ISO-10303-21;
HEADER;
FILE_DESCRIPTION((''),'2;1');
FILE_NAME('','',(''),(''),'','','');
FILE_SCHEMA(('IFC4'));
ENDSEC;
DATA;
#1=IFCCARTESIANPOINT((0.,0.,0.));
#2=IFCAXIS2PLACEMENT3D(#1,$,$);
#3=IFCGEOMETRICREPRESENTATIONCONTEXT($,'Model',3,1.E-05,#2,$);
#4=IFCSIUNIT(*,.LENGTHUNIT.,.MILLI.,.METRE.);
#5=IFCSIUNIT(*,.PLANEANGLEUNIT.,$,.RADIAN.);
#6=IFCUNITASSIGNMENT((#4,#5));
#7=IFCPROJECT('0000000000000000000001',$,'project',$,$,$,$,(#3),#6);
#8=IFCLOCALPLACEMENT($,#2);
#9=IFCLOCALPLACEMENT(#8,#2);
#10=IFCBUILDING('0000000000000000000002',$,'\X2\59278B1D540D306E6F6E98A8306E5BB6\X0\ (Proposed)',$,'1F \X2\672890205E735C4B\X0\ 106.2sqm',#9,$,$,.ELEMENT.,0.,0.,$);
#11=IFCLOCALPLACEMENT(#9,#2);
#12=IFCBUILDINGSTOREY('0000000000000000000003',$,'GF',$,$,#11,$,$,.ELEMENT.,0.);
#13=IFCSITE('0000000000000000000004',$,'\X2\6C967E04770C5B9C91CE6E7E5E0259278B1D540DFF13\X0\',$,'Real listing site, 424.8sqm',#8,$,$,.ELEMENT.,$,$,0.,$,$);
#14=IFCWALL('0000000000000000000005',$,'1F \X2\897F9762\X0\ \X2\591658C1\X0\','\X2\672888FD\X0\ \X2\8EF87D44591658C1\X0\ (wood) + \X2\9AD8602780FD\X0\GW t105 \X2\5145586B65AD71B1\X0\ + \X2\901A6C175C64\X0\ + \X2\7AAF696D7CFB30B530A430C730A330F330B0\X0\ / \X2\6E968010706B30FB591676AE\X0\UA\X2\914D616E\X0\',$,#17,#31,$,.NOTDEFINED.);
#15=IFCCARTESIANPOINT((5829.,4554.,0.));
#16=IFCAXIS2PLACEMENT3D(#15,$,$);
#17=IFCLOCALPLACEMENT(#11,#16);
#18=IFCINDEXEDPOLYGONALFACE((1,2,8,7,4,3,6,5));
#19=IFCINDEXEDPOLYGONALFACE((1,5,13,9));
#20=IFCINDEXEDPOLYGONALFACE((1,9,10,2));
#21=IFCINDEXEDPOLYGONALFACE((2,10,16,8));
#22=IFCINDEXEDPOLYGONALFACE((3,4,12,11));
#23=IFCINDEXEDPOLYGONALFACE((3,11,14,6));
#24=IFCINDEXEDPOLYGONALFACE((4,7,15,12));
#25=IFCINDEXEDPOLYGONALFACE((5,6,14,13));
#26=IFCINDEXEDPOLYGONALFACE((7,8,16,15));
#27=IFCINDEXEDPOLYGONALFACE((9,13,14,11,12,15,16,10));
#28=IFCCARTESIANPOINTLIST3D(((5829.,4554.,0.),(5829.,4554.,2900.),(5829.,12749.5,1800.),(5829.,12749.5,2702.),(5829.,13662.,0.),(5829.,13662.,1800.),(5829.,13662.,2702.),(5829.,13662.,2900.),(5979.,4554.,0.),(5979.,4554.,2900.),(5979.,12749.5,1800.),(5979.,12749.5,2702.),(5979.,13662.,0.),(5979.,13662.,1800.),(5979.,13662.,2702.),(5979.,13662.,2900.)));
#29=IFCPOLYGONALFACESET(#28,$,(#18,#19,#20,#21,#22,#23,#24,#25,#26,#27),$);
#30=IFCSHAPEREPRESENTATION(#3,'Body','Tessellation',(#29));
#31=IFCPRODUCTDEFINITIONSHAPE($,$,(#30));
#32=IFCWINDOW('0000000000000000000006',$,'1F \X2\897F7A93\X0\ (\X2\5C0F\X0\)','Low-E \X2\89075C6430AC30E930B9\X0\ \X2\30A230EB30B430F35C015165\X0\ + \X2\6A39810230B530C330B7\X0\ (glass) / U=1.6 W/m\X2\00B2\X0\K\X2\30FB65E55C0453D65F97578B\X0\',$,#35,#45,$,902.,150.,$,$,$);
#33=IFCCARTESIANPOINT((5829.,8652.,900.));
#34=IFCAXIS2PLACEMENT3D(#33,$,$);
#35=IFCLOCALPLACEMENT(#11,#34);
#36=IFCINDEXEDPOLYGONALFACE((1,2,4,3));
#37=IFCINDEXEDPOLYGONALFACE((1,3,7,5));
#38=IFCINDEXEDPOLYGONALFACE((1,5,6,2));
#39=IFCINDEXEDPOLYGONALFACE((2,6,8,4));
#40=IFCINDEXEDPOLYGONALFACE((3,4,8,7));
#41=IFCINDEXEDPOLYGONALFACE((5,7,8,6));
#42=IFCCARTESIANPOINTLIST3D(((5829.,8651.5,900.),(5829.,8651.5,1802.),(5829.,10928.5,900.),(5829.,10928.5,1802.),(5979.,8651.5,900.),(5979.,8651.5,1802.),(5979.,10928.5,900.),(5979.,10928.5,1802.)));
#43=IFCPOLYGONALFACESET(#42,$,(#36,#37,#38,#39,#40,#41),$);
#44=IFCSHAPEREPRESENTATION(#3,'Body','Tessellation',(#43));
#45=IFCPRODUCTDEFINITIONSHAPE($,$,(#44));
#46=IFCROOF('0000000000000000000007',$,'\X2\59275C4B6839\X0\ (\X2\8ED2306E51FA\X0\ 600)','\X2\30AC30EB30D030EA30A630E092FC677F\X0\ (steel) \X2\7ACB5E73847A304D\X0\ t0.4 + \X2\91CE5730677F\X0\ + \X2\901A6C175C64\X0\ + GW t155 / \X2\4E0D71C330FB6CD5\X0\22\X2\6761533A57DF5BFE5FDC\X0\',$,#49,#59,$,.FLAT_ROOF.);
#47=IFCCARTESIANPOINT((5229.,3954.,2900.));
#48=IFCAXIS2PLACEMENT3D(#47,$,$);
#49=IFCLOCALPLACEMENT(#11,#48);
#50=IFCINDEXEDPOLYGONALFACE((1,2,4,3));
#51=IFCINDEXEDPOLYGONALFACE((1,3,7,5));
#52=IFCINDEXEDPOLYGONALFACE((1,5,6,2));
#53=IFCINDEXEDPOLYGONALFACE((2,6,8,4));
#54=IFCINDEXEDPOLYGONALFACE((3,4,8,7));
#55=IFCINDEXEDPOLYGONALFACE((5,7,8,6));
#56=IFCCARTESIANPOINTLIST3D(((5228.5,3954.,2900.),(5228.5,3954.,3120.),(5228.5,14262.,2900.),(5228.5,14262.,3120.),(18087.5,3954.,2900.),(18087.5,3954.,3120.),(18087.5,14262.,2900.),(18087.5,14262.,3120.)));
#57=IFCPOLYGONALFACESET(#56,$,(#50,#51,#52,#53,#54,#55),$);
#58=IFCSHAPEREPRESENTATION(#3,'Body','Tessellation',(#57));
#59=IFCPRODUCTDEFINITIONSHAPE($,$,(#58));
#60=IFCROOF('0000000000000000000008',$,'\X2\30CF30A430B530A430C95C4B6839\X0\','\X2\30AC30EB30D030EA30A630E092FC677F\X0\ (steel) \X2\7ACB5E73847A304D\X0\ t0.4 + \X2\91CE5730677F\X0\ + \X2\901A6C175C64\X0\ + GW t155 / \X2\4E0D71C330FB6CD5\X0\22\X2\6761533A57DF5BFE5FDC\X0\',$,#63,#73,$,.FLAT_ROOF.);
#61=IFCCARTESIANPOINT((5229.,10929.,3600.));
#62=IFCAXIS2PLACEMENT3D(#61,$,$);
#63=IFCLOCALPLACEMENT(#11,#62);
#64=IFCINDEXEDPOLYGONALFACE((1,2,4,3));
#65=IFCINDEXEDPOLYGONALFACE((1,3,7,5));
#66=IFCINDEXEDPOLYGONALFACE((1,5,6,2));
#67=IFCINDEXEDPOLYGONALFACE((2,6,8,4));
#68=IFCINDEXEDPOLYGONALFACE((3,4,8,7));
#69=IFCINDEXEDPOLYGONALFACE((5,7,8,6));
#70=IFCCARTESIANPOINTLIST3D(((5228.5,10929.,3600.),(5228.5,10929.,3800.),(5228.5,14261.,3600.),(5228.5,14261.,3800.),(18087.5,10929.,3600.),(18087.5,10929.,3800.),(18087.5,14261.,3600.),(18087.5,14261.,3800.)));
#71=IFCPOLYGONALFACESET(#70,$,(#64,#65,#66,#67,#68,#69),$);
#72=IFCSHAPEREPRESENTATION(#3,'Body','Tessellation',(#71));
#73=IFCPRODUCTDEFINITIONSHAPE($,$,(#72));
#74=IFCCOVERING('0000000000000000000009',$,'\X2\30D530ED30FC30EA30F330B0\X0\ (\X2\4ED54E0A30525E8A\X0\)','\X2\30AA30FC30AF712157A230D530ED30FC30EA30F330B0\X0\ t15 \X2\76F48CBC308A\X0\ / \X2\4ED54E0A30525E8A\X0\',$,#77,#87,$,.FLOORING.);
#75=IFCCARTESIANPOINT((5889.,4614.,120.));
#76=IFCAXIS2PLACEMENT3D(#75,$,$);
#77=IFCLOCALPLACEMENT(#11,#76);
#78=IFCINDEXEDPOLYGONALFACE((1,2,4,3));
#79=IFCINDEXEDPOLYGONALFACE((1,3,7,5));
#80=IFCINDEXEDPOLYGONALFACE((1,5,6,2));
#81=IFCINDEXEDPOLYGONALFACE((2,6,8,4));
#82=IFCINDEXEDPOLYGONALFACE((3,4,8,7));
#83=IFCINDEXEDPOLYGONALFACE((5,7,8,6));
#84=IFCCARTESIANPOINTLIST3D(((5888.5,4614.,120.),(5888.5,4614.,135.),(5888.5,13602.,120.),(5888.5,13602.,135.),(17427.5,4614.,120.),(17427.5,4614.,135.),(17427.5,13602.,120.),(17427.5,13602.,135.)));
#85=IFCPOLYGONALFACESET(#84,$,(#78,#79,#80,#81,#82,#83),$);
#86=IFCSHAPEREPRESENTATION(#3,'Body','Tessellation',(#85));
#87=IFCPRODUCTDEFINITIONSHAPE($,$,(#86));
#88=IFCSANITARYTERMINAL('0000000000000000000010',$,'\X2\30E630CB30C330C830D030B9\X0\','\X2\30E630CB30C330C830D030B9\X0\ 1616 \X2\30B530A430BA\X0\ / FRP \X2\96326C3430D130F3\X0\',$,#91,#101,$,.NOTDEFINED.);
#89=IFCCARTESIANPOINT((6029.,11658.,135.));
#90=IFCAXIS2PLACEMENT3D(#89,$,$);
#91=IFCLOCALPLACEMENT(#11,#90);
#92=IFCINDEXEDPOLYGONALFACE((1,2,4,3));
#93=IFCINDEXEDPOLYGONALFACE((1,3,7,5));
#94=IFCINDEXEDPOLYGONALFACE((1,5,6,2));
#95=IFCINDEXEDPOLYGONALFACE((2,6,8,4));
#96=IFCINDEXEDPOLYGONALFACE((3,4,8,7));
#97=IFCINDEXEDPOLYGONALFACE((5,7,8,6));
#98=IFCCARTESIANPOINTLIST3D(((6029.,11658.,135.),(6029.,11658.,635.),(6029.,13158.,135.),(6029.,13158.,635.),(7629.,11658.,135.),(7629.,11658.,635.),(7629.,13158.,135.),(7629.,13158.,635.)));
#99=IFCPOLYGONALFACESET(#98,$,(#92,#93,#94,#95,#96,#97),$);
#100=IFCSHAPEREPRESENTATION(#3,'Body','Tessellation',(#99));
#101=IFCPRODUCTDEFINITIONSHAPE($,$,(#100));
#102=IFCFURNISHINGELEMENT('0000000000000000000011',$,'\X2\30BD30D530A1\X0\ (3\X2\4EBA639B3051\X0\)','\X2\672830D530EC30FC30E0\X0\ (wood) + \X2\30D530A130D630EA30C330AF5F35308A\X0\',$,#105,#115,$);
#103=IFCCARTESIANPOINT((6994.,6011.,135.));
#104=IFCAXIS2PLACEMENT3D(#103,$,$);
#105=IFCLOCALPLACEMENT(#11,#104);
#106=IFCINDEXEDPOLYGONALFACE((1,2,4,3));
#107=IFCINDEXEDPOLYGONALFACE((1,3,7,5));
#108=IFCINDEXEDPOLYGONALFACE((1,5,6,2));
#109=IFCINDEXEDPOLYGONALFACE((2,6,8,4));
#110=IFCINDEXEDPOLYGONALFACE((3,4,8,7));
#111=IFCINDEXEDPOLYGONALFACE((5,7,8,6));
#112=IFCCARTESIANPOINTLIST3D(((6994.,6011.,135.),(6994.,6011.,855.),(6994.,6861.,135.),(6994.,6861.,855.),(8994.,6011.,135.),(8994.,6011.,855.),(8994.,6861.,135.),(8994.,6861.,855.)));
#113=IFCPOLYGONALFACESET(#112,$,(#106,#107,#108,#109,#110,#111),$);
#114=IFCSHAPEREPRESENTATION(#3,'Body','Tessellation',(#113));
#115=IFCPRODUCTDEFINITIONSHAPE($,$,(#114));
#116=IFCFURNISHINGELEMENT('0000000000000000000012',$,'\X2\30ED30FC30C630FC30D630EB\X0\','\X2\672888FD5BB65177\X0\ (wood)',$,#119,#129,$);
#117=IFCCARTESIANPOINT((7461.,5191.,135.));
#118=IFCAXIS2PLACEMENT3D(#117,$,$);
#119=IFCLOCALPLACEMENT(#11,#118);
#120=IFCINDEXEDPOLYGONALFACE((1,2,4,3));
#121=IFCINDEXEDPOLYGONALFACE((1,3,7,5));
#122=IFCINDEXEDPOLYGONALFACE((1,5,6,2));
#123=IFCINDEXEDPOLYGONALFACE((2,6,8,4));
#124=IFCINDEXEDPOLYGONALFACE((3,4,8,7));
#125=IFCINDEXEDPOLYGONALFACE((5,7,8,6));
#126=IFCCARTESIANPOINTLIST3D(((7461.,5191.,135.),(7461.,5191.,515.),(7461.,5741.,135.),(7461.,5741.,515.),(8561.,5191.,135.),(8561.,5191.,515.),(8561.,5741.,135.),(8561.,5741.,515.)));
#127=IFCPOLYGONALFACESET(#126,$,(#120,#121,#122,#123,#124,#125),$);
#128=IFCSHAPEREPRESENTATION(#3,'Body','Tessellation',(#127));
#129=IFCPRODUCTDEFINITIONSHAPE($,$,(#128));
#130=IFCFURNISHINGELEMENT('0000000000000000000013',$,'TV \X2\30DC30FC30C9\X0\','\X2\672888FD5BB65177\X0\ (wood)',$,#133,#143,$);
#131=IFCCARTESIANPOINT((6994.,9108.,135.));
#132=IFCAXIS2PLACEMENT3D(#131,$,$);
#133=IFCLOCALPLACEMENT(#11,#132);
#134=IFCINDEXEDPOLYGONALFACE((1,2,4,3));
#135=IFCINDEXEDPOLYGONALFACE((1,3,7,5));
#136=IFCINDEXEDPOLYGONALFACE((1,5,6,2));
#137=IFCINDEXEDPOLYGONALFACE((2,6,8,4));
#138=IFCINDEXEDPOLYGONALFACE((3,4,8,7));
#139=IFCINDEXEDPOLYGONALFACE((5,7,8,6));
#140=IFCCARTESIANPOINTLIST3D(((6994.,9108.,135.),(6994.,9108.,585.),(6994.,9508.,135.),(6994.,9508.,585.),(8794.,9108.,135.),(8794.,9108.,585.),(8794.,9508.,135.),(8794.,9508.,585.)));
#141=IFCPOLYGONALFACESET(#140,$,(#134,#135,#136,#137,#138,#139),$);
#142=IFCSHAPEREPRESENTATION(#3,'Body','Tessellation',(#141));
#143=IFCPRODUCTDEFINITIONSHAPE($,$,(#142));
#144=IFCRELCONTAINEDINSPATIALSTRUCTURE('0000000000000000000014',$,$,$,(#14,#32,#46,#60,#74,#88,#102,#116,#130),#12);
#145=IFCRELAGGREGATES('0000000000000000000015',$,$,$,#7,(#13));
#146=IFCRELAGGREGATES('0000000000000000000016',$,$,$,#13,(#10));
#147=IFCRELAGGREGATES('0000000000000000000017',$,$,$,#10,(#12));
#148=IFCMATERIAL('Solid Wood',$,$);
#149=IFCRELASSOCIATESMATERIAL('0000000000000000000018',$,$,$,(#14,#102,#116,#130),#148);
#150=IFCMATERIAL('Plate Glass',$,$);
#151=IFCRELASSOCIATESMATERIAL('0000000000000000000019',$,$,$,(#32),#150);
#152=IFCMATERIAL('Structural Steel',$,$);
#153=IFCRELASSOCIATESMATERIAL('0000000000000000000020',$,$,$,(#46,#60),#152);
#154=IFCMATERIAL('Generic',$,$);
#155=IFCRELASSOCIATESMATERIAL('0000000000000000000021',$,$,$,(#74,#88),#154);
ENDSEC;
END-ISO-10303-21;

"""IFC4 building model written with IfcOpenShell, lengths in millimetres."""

from ifc_helpers import new_model, si_unit, frame, frame_2d, origin, place, context, project, spatial, rectangle, extrude, material, element, fill, save


model = new_model("IFC4")

# Units and contexts
model_context = context("Model", 3, precision=1e-05, world=origin())
ifc_project = project(units=[si_unit("LENGTHUNIT", "METRE", prefix="MILLI"), si_unit("PLANEANGLEUNIT", "RADIAN")], contexts=[model_context])

# Site, building, storey
site_placement = place(None, origin())
site = spatial("IfcSite", under=ifc_project, at=site_placement, Name="沖縄県宜野湾市大謝名３", ObjectType="Real listing site, 424.8sqm", CompositionType="ELEMENT", RefElevation=0.0)
building_placement = place(site_placement, origin())
building = spatial("IfcBuilding", under=site, at=building_placement, Name="大謝名の潮風の家 (Proposed)", ObjectType="1F 木造平屋 106.2sqm", CompositionType="ELEMENT", ElevationOfRefHeight=0.0, ElevationOfTerrain=0.0)
storey_placement = place(building_placement, origin())
storey = spatial("IfcBuildingStorey", under=building, at=storey_placement, Name="GF", CompositionType="ELEMENT", Elevation=0.0)

# Shared definitions
ifc_material_1 = material(Name="Solid Wood")

# Shared definitions
ifc_material_2 = material(Name="Plate Glass")

# Wall, opening, window
wall_1_placement = place(storey_placement, frame((5829.0, 4554.0, 0.0)))
wall_1 = element("IfcWall", 1, at=wall_1_placement, inside=storey, material=ifc_material_1, Name="1F 西面 外壁", Description="木製 軸組外壁 (wood) + 高性能GW t105 充填断熱 + 通気層 + 窯業系サイディング / 準耐火・外皮UA配慮", PredefinedType="NOTDEFINED", context=model_context, shape_type="SweptSolid", body=[
    extrude(rectangle(XDim=150.0, YDim=9108.0, at=frame_2d((75.0, 4554.0))), frame((5829.0, 4554.0, 0.0)), (0.0, 0.0, 1.0), 2900.0),
])
opening_1_placement = place(storey_placement, frame((5829.0, 8652.0, 900.0)))
opening_1 = element("IfcOpeningElement", 2, at=opening_1_placement, cuts=wall_1, PredefinedType="NOTDEFINED", context=model_context, shape_type="SweptSolid", body=[
    extrude(rectangle(XDim=150.0, YDim=2277.0, at=frame_2d((75.0, 1138.0))), frame((5829.0, 8652.0, 900.0)), (0.0, 0.0, 1.0), 902.0),
])
window_1_placement = place(storey_placement, frame((5829.0, 8652.0, 900.0)))
window_1 = element("IfcWindow", 3, at=window_1_placement, inside=storey, material=ifc_material_2, Name="1F 西窓 (小)", Description="Low-E 複層ガラス アルゴン封入 + 樹脂サッシ (glass) / U=1.6 W/m²K・日射取得型", OverallHeight=902.0, OverallWidth=150.0, context=model_context, shape_type="SweptSolid", body=[
    extrude(rectangle(XDim=150.0, YDim=2277.0, at=frame_2d((75.0, 1138.0))), frame((5829.0, 8652.0, 900.0)), (0.0, 0.0, 1.0), 902.0),
])
fill(opening_1, window_1)

# Roofs
ifc_material_3 = material(Name="Structural Steel")
roof_1_placement = place(storey_placement, frame((5229.0, 3954.0, 2900.0)))
element("IfcRoof", 4, at=roof_1_placement, inside=storey, material=ifc_material_3, Name="大屋根 (軒の出 600)", Description="ガルバリウム鋼板 (steel) 立平葺き t0.4 + 野地板 + 通気層 + GW t155 / 不燃・法22条区域対応", PredefinedType="FLAT_ROOF", context=model_context, shape_type="SweptSolid", body=[
    extrude(rectangle(XDim=12859.0, YDim=10308.0, at=frame_2d((6429.0, 5154.0))), frame((5229.0, 3954.0, 2900.0)), (0.0, 0.0, 1.0), 220.0),
])
roof_2_placement = place(storey_placement, frame((5229.0, 10929.0, 3600.0)))
element("IfcRoof", 5, at=roof_2_placement, inside=storey, material=ifc_material_3, Name="ハイサイド屋根", Description="ガルバリウム鋼板 (steel) 立平葺き t0.4 + 野地板 + 通気層 + GW t155 / 不燃・法22条区域対応", PredefinedType="FLAT_ROOF", context=model_context, shape_type="SweptSolid", body=[
    extrude(rectangle(XDim=12859.0, YDim=3332.0, at=frame_2d((6429.0, 1666.0))), frame((5229.0, 10929.0, 3600.0)), (0.0, 0.0, 1.0), 200.0),
])

# Covering
ifc_material_4 = material(Name="Generic")
covering_placement = place(storey_placement, frame((5889.0, 4614.0, 120.0)))
element("IfcCovering", 6, at=covering_placement, inside=storey, material=ifc_material_4, Name="フローリング (仕上げ床)", Description="オーク無垢フローリング t15 直貼り / 仕上げ床", PredefinedType="FLOORING", context=model_context, shape_type="SweptSolid", body=[
    extrude(rectangle(XDim=11539.0, YDim=8988.0, at=frame_2d((5769.0, 4494.0))), frame((5889.0, 4614.0, 120.0)), (0.0, 0.0, 1.0), 15.0),
])

# Sanitary terminal
sanitary_terminal_placement = place(storey_placement, frame((6029.0, 11658.0, 135.0)))
element("IfcSanitaryTerminal", 7, at=sanitary_terminal_placement, inside=storey, material=ifc_material_4, Name="ユニットバス", Description="ユニットバス 1616 サイズ / FRP 防水パン", PredefinedType="NOTDEFINED", context=model_context, shape_type="SweptSolid", body=[
    extrude(rectangle(XDim=1600.0, YDim=1500.0, at=frame_2d((800.0, 750.0))), frame((6029.0, 11658.0, 135.0)), (0.0, 0.0, 1.0), 500.0),
])

# Furnishing elements
furnishing_1_placement = place(storey_placement, frame((6994.0, 6011.0, 135.0)))
element("IfcFurnishingElement", 8, at=furnishing_1_placement, inside=storey, material=ifc_material_1, Name="ソファ (3人掛け)", Description="木フレーム (wood) + ファブリック張り", context=model_context, shape_type="SweptSolid", body=[
    extrude(rectangle(XDim=2000.0, YDim=850.0, at=frame_2d((1000.0, 425.0))), frame((6994.0, 6011.0, 135.0)), (0.0, 0.0, 1.0), 720.0),
])
furnishing_2_placement = place(storey_placement, frame((7461.0, 5191.0, 135.0)))
element("IfcFurnishingElement", 9, at=furnishing_2_placement, inside=storey, material=ifc_material_1, Name="ローテーブル", Description="木製家具 (wood)", context=model_context, shape_type="SweptSolid", body=[
    extrude(rectangle(XDim=1100.0, YDim=550.0, at=frame_2d((550.0, 275.0))), frame((7461.0, 5191.0, 135.0)), (0.0, 0.0, 1.0), 380.0),
])
furnishing_3_placement = place(storey_placement, frame((6994.0, 9108.0, 135.0)))
element("IfcFurnishingElement", 10, at=furnishing_3_placement, inside=storey, material=ifc_material_1, Name="TV ボード", Description="木製家具 (wood)", context=model_context, shape_type="SweptSolid", body=[
    extrude(rectangle(XDim=1800.0, YDim=400.0, at=frame_2d((900.0, 200.0))), frame((6994.0, 9108.0, 135.0)), (0.0, 0.0, 1.0), 450.0),
])

save(model, "model.ifc")
